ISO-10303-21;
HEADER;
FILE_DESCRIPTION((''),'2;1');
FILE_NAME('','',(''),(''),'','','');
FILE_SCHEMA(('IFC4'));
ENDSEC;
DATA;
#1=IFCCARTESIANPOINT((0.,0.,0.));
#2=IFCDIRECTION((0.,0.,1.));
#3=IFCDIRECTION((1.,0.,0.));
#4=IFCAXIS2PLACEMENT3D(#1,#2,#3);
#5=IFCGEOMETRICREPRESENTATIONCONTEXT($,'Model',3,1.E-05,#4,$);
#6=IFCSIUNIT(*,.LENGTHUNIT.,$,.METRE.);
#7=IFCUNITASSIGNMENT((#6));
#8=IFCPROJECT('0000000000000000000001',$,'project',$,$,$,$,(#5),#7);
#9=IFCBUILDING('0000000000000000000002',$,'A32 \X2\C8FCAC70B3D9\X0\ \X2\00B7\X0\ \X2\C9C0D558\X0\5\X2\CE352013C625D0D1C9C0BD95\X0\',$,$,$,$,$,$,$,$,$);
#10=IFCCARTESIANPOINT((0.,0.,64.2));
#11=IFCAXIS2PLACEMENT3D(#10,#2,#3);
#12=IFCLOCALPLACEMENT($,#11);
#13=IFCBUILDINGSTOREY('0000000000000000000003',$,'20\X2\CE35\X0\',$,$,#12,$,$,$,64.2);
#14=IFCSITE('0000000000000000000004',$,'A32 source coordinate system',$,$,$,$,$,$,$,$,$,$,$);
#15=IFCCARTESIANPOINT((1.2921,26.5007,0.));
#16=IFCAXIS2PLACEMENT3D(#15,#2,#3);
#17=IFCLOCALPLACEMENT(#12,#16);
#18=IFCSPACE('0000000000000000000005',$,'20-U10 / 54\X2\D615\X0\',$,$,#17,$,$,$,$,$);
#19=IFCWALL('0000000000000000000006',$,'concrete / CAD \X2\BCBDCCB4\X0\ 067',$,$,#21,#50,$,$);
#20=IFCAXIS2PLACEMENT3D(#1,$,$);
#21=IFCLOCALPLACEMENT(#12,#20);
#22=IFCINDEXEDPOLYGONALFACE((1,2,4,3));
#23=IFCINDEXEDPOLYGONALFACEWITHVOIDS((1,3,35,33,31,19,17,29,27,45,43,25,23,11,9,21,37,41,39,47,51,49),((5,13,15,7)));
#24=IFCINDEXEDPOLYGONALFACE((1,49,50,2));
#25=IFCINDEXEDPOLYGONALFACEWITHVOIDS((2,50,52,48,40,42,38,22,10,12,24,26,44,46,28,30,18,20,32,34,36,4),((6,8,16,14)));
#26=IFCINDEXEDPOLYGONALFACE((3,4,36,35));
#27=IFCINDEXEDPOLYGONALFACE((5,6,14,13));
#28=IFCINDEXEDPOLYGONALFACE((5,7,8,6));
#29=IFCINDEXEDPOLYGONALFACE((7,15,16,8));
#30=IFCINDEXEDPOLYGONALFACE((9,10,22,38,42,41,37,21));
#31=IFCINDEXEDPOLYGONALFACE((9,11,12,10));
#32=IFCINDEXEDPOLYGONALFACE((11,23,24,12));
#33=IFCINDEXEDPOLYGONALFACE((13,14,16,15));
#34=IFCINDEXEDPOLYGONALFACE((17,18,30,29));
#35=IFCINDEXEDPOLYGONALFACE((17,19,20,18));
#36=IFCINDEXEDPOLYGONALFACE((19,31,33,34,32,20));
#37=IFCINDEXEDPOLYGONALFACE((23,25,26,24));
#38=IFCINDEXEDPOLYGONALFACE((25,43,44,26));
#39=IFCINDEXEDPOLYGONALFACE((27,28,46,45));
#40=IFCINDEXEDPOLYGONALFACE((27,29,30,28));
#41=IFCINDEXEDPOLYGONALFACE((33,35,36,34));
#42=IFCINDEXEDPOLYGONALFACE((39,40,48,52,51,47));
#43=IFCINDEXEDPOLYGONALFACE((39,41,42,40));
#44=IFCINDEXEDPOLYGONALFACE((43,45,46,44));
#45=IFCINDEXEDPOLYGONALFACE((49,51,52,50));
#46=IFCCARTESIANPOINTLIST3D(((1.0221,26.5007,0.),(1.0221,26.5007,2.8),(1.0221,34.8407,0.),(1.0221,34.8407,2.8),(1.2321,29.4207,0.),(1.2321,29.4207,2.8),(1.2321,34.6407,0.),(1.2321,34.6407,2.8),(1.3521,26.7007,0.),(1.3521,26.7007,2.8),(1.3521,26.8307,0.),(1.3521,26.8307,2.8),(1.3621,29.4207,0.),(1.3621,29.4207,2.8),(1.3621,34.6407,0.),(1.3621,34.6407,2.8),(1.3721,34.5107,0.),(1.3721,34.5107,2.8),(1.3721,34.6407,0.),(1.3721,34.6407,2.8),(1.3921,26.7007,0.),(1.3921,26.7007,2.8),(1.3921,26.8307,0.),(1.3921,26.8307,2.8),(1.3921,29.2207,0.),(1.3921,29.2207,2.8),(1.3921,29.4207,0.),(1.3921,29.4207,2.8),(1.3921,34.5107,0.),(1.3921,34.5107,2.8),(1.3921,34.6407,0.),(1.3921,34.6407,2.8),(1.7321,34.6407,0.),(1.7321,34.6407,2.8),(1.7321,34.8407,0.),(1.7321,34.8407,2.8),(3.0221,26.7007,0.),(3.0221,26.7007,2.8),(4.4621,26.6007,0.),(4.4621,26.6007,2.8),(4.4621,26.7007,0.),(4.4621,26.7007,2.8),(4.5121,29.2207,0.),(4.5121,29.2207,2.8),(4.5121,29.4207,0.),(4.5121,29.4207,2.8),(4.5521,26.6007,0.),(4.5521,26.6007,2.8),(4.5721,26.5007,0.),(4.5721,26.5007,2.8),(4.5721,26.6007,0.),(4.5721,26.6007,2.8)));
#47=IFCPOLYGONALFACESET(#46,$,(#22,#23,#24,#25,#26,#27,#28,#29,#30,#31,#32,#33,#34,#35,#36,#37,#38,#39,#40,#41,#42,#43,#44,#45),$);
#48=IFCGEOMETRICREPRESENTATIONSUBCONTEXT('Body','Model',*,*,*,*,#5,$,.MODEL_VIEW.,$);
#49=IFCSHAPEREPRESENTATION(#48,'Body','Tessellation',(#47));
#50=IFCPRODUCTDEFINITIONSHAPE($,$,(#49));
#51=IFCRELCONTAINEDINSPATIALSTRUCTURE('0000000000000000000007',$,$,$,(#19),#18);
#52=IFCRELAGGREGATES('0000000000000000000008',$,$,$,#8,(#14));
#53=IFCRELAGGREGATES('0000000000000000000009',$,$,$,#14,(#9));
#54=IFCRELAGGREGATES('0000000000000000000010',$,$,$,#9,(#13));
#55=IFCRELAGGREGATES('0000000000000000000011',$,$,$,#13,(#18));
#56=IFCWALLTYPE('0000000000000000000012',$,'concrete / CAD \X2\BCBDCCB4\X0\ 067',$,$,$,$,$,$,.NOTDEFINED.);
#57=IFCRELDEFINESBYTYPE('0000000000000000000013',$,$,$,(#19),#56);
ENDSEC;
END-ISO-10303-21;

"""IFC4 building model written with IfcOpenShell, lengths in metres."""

from ifc_helpers import new_model, si_unit, frame, origin, origin_with_axes, place, context, subcontext, project, spatial, polyline, outline, extrude, source, transform, mapped, type_object, type_shapes, element, save


model = new_model("IFC4")

# Units and contexts
model_context = context("Model", 3, precision=1e-05, world=origin_with_axes())
body_context = subcontext(model_context, "Body", "Model", "MODEL_VIEW")
ifc_project = project(units=[si_unit("LENGTHUNIT", "METRE")], contexts=[model_context])

# Site, building, storey, space
site = spatial("IfcSite", under=ifc_project, Name="A32 source coordinate system")
building = spatial("IfcBuilding", under=site, Name="A32 주거동 · 지하5층–옥탑지붕")
storey_placement = place(None, frame((0.0, 0.0, 64.2), z_axis=(0.0, 0.0, 1.0), x_axis=(1.0, 0.0, 0.0)))
storey = spatial("IfcBuildingStorey", under=building, at=storey_placement, Name="20층", Elevation=64.2)
space_placement = place(storey_placement, frame((1.2921, 26.5007, 0.0), z_axis=(0.0, 0.0, 1.0), x_axis=(1.0, 0.0, 0.0)))
space = spatial("IfcSpace", under=storey, at=space_placement, Name="20-U10 / 54형")

# Wall
wall_type_1 = type_object("IfcWallType", Name="concrete / CAD 벽체 067", PredefinedType="NOTDEFINED")
shared_shape_1 = source(origin(), body_context, "Body", "SweptSolid", [
    extrude(outline(polyline([(0.1, 0.2), (1.73, 0.2), (3.17, 0.2), (3.17, 0.1), (3.26, 0.1), (3.28, 0.1), (3.28, 0.0), (-0.27, 0.0), (-0.27, 8.34), (0.44, 8.34), (0.44, 8.14), (0.1, 8.14), (0.08, 8.14), (0.08, 8.01), (0.1, 8.01), (0.1, 2.92), (3.22, 2.92), (3.22, 2.72), (0.1, 2.72), (0.1, 0.33), (0.06, 0.33), (0.06, 0.2), (0.1, 0.2)]), holes=[polyline([(-0.06, 8.14), (-0.06, 2.92), (0.07, 2.92), (0.07, 8.14), (-0.06, 8.14)])]), origin(), (0.0, 0.0, 1.0), 2.8),
])
type_shapes(wall_type_1, [shared_shape_1])
wall_1_placement = place(space_placement, origin_with_axes())
element("IfcWall", 1, at=wall_1_placement, inside=space, type_object=wall_type_1, Name="concrete / CAD 벽체 067", context=body_context, shape_type="MappedRepresentation", body=[
    mapped(shared_shape_1, transform((0.0, 0.0, 0.0), scale=1.0)),
])

save(model, "model.ifc")
